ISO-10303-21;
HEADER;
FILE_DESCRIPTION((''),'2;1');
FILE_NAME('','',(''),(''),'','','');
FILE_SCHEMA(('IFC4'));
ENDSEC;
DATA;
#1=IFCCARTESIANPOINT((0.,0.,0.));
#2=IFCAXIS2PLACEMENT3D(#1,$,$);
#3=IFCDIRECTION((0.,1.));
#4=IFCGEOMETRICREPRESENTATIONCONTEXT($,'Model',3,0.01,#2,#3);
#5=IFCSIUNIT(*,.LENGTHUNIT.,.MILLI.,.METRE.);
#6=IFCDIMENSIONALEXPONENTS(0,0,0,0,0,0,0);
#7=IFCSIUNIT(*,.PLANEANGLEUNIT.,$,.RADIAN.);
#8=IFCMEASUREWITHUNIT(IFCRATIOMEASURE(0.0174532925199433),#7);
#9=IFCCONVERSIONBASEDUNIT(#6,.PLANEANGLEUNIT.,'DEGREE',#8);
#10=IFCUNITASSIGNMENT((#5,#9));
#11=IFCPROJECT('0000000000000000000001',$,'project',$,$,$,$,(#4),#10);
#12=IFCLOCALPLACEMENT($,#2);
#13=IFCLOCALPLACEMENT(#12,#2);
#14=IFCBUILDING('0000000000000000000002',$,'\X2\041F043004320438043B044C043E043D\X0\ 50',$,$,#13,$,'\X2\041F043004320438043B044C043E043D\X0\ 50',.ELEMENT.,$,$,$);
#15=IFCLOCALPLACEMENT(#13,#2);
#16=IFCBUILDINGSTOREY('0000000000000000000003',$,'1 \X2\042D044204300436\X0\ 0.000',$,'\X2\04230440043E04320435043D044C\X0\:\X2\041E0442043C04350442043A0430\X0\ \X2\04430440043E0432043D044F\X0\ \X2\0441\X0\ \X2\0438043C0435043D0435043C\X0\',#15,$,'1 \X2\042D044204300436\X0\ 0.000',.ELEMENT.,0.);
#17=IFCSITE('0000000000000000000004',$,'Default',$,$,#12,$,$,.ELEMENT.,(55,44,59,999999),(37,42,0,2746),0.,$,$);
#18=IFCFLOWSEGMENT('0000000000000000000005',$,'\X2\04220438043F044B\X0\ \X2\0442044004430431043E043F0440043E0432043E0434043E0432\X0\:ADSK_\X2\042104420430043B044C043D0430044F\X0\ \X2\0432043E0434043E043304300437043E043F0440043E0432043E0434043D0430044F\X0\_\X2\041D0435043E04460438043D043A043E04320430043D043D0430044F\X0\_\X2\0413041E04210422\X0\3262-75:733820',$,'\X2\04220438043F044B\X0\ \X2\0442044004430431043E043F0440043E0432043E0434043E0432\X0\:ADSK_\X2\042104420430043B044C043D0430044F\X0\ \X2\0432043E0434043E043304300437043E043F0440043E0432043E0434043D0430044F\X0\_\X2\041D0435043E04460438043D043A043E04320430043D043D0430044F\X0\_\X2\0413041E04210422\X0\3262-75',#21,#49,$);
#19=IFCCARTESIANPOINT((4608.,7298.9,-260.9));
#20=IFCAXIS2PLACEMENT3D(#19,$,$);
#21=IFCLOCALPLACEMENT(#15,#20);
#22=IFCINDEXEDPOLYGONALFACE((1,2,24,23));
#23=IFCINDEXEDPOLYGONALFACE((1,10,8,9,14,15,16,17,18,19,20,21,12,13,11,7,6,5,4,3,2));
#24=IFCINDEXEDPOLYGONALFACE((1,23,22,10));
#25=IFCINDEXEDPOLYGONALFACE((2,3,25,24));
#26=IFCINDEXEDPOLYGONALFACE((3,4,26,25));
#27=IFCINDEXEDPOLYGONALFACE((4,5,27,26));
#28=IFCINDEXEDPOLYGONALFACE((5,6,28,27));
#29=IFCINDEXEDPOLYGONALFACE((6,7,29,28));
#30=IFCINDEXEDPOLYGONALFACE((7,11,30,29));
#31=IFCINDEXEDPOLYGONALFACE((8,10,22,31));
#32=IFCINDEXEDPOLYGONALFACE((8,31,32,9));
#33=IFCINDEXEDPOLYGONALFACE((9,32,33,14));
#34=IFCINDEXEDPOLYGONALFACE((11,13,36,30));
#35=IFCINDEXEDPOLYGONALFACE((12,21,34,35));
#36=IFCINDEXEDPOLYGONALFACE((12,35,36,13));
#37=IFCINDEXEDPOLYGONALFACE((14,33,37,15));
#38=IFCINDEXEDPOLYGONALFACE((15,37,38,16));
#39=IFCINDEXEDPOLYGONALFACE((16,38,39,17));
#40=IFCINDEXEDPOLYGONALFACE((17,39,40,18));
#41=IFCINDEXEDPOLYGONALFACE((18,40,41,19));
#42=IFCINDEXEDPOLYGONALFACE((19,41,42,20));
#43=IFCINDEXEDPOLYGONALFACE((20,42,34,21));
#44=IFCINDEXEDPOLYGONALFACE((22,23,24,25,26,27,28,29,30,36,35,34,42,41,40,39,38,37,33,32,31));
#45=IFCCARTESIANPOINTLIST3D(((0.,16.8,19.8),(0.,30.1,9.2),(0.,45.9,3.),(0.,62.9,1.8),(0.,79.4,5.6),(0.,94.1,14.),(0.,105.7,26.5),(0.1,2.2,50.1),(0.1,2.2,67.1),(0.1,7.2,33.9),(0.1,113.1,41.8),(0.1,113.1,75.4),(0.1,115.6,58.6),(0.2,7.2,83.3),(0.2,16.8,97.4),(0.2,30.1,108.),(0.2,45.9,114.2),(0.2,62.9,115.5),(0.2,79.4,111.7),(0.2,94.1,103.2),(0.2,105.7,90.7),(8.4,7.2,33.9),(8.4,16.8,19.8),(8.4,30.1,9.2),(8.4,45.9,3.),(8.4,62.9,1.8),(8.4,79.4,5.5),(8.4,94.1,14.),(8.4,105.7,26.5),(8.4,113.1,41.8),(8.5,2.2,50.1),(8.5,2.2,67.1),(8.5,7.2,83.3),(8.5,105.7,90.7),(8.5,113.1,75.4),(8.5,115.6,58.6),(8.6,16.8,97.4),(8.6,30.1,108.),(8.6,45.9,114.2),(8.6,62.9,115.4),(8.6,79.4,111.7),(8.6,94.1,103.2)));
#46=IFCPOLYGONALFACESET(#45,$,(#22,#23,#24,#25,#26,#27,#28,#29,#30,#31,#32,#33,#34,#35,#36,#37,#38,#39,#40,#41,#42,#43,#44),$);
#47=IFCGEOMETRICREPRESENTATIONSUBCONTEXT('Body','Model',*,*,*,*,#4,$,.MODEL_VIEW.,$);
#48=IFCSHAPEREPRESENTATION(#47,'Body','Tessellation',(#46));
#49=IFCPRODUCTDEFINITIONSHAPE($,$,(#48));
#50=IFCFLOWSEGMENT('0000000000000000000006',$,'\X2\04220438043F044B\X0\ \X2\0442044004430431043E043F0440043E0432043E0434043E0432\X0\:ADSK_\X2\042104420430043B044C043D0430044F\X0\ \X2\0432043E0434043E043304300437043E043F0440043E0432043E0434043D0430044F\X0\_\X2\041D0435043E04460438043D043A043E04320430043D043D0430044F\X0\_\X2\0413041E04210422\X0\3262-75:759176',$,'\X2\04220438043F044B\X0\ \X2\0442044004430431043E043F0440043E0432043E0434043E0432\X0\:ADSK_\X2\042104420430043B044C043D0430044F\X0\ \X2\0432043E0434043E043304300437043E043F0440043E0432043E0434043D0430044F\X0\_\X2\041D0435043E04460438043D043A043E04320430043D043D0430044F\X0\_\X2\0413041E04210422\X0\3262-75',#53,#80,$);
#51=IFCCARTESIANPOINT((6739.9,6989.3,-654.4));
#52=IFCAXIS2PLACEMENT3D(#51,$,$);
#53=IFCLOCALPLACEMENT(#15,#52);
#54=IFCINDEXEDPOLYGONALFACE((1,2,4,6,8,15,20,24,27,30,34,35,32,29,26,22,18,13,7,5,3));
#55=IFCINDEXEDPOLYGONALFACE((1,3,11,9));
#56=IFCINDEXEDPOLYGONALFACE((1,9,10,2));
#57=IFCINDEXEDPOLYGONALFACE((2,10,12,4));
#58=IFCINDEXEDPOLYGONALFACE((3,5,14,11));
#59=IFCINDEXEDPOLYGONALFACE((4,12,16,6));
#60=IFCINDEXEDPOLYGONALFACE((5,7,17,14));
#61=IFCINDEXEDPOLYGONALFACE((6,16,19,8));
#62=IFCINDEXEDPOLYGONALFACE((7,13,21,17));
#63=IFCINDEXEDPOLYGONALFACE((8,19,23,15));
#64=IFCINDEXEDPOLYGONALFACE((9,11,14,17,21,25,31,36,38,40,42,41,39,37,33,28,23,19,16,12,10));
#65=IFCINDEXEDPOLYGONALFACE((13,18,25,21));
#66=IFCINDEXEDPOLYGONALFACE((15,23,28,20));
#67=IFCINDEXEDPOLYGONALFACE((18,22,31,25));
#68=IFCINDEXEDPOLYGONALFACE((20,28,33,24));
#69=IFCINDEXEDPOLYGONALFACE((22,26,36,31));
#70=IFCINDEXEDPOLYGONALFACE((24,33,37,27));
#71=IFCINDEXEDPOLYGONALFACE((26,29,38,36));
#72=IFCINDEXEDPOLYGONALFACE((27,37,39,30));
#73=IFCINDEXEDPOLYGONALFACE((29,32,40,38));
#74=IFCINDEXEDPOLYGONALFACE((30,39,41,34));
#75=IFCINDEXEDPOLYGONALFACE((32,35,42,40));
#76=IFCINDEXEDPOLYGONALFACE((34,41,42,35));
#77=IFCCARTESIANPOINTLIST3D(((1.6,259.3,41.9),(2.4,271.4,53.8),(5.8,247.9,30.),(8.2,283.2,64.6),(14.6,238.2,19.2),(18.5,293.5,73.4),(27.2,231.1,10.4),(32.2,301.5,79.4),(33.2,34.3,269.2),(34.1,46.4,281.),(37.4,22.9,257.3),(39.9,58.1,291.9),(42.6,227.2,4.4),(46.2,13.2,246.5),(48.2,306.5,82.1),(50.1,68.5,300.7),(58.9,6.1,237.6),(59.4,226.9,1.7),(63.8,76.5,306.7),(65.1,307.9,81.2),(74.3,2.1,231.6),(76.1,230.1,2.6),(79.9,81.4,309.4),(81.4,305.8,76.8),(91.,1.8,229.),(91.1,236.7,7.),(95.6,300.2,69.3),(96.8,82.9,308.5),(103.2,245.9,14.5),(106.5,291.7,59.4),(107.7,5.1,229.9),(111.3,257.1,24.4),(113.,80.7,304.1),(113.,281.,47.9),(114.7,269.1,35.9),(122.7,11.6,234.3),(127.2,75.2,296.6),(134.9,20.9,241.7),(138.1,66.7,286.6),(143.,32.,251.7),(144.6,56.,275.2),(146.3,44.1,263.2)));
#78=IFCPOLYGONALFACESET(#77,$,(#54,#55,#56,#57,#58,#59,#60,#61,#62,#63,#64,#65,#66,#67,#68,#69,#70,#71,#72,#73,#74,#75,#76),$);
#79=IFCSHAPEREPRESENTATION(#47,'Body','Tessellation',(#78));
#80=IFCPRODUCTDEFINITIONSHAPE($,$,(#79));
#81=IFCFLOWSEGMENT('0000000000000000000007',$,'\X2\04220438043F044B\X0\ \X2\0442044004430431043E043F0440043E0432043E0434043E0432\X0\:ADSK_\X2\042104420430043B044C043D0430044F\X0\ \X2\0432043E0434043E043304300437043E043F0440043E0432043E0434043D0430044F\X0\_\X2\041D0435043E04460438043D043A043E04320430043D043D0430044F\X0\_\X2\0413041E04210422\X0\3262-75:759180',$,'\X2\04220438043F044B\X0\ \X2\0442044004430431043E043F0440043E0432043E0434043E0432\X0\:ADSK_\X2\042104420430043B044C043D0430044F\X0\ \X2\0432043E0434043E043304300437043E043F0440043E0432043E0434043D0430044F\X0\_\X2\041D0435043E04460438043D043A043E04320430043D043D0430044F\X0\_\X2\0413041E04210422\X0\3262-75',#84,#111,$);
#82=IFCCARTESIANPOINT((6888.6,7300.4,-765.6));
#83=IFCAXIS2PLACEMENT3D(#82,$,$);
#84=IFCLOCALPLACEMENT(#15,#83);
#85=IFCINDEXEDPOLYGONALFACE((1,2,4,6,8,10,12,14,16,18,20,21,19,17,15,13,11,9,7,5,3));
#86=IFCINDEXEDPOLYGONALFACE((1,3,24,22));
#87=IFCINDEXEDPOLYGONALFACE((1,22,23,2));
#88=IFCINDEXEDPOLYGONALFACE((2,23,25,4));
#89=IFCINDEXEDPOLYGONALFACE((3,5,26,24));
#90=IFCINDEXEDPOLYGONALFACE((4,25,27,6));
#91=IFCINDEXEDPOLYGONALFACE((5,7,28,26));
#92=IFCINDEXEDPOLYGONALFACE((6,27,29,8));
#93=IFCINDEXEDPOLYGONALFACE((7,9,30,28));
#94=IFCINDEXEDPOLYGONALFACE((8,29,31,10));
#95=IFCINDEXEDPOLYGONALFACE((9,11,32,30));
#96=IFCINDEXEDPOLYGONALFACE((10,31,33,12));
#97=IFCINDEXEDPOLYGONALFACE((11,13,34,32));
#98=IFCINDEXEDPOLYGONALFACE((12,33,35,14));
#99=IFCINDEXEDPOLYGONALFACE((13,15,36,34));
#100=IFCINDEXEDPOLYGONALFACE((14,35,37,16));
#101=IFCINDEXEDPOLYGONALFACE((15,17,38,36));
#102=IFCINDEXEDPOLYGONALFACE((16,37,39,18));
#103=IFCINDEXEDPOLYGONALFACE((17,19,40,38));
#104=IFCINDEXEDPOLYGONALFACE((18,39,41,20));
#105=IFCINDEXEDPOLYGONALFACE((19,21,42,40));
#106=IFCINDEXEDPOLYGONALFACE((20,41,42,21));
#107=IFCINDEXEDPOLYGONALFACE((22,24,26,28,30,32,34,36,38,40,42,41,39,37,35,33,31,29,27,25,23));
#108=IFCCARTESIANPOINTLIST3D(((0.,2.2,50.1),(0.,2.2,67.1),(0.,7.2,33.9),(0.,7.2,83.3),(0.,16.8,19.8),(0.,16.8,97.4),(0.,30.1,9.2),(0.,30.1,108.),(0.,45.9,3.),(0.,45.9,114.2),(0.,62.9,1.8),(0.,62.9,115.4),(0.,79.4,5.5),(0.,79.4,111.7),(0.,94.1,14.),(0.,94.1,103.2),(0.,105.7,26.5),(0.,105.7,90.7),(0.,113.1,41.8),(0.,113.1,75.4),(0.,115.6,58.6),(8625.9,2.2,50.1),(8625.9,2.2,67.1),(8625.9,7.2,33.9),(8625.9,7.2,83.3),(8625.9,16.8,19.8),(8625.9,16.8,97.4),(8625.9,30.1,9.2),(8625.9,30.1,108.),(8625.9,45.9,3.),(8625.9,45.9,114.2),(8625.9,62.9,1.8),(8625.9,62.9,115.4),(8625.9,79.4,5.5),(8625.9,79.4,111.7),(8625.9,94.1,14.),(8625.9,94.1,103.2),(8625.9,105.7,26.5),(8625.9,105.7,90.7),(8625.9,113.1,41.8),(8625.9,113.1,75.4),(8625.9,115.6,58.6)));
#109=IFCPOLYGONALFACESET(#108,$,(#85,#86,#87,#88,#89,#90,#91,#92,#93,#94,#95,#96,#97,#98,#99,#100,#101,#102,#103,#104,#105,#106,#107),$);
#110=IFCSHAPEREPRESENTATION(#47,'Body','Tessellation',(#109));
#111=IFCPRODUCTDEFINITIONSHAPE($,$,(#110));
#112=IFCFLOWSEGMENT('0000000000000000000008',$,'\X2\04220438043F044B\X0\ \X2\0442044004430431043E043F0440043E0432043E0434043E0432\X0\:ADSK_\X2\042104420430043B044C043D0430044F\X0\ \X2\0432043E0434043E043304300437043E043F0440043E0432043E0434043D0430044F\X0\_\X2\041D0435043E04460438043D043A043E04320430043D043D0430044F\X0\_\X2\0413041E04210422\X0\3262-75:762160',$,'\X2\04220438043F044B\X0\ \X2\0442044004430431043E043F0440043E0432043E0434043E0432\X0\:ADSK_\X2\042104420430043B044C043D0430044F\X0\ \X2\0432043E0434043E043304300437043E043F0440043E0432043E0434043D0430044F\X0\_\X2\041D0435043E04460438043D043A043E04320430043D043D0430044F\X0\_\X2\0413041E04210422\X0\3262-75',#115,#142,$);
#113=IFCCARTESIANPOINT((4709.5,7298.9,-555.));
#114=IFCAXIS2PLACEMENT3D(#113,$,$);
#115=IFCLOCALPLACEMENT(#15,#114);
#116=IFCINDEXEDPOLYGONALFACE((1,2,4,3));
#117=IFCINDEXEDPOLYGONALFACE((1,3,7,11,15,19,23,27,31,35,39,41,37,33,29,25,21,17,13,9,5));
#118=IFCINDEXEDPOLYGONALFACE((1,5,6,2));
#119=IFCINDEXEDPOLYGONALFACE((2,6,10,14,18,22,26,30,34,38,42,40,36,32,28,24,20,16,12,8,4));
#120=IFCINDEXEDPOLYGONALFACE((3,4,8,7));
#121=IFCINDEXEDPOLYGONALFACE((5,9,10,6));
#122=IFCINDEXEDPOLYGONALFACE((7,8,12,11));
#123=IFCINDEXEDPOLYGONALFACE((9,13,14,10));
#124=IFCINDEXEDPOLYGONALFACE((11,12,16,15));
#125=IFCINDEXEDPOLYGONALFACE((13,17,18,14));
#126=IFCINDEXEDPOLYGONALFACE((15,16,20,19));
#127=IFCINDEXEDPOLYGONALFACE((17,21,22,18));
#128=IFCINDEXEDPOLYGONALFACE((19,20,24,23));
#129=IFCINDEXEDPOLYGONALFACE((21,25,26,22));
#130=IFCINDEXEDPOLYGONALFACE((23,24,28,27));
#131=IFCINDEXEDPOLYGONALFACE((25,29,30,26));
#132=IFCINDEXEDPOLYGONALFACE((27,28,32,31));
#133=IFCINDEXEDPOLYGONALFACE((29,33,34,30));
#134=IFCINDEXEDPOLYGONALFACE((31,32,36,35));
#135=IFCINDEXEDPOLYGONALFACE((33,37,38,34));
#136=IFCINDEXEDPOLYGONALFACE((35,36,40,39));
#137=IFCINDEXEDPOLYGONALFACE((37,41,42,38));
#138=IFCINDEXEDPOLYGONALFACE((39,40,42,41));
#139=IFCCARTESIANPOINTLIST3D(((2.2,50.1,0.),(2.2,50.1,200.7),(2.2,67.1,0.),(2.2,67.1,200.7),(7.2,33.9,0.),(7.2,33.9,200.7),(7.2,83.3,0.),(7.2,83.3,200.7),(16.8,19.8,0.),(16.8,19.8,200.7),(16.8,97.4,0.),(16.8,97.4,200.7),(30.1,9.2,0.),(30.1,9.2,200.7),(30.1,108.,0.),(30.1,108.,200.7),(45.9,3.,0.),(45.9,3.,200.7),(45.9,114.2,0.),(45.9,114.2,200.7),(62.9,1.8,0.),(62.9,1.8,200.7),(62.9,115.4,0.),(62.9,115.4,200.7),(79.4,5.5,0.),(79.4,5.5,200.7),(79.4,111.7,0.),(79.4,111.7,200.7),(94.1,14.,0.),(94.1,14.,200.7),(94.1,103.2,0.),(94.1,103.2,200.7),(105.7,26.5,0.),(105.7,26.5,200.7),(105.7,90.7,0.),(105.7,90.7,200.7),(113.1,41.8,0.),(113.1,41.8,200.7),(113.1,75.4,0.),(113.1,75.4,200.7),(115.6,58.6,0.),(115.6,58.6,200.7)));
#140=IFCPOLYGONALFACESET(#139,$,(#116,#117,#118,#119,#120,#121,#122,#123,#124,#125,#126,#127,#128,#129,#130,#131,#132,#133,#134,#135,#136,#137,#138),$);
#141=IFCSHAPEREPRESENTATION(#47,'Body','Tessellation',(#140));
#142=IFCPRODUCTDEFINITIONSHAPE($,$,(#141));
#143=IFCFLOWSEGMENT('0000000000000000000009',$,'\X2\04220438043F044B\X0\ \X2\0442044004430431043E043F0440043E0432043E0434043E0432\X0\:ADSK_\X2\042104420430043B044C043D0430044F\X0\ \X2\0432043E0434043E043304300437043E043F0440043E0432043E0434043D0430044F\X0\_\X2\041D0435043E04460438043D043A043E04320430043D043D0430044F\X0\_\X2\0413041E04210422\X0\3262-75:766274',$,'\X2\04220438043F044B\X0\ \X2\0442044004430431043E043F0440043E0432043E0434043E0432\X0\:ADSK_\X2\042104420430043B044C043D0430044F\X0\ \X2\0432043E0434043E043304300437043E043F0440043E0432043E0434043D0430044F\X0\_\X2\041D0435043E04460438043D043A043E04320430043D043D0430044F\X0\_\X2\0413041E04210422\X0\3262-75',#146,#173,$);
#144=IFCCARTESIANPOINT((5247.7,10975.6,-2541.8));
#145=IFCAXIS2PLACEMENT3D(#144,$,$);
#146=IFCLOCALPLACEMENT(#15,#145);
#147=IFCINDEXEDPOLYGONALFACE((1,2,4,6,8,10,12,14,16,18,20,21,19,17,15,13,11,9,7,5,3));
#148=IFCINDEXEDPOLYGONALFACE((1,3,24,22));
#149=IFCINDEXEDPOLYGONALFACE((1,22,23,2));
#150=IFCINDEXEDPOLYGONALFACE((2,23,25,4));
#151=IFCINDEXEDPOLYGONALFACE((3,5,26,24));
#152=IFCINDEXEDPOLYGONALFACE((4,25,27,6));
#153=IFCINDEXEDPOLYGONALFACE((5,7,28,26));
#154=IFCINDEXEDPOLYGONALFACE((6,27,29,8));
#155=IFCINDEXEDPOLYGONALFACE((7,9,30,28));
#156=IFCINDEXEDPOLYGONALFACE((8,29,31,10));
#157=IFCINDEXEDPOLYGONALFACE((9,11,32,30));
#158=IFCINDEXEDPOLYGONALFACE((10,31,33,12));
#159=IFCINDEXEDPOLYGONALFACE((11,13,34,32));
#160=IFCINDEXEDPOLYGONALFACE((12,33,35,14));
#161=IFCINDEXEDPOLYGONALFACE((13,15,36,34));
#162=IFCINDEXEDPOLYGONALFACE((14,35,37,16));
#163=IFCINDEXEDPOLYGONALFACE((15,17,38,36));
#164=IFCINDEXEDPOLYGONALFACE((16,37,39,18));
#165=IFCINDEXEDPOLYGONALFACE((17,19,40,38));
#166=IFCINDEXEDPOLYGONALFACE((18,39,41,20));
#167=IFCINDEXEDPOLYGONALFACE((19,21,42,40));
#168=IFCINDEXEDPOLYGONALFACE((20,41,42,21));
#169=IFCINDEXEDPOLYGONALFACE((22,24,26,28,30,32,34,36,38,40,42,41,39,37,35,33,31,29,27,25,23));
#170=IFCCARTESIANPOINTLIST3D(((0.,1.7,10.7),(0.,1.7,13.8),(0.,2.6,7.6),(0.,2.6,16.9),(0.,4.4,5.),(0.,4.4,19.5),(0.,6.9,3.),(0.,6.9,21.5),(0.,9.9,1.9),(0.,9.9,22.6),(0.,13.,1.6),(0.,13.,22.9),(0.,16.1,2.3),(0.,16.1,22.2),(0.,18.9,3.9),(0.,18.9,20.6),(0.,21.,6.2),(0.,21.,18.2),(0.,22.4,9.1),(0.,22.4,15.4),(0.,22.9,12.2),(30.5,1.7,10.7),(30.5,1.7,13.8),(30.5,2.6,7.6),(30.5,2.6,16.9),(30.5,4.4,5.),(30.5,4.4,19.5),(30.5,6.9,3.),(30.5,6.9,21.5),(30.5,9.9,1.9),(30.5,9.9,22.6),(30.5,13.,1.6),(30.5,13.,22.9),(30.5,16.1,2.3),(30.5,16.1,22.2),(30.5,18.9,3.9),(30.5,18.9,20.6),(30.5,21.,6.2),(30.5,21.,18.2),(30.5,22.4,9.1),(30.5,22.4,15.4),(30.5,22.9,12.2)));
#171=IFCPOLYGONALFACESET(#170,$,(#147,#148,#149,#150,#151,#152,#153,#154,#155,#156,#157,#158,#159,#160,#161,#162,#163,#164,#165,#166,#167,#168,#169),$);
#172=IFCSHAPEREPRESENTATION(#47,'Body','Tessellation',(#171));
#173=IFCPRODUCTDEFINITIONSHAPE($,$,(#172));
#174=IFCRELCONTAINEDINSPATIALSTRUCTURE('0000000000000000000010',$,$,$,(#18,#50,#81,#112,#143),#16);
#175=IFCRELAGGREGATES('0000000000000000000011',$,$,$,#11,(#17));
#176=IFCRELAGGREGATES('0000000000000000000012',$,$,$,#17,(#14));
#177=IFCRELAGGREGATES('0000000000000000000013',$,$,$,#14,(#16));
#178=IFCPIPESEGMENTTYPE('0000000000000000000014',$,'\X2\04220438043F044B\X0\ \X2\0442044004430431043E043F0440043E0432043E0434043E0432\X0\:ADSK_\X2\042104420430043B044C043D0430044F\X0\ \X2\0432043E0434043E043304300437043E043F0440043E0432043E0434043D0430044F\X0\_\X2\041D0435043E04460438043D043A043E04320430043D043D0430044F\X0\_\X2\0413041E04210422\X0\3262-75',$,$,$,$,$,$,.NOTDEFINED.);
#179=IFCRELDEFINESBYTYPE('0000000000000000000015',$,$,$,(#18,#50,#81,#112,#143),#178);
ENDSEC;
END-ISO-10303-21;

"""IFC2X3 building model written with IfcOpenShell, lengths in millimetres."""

from ifc_helpers import new_model, entity, si_unit, converted_unit, direction, frame, frame_2d, origin, origin_2d_with_axis, place, context, subcontext, project, spatial, circle, extrude, type_object, element, save


model = new_model("IFC2X3")

# Units and contexts
model_context = context("Model", 3, precision=0.01, world=origin(), true_north=direction((0.0, 1.0)))
body_context = subcontext(model_context, "Body", "Model", "MODEL_VIEW")
ifc_project = project(units=[si_unit("LENGTHUNIT", "METRE", prefix="MILLI"), converted_unit("PLANEANGLEUNIT", "DEGREE", entity("IfcRatioMeasure", 0.0174532925199433), si_unit("PLANEANGLEUNIT", "RADIAN"), dimensions=[0, 0, 0, 0, 0, 0, 0])], contexts=[model_context])

# Site, building, storey
site_placement = place(None, origin())
site = spatial("IfcSite", under=ifc_project, at=site_placement, Name="Default", CompositionType="ELEMENT", RefLatitude=(55, 44, 59, 999999), RefLongitude=(37, 42, 0, 2746), RefElevation=0.0)
building_placement = place(site_placement, origin())
building = spatial("IfcBuilding", under=site, at=building_placement, Name="Павильон 50", LongName="Павильон 50", CompositionType="ELEMENT")
storey_placement = place(building_placement, origin())
storey = spatial("IfcBuildingStorey", under=building, at=storey_placement, Name="1 Этаж 0.000", ObjectType="Уровень:Отметка уровня с именем", LongName="1 Этаж 0.000", CompositionType="ELEMENT", Elevation=0.0)

# Flow segments
pipe_segment_type = type_object("IfcPipeSegmentType", Name="Типы трубопроводов:ADSK_Стальная водогазопроводная_Неоцинкованная_ГОСТ3262-75", PredefinedType="NOTDEFINED")
flow_segment_1_placement = place(storey_placement, frame((4608.0, 7298.9, -260.9)))
element("IfcFlowSegment", 1, at=flow_segment_1_placement, inside=storey, type_object=pipe_segment_type, Name="Типы трубопроводов:ADSK_Стальная водогазопроводная_Неоцинкованная_ГОСТ3262-75:733820", ObjectType="Типы трубопроводов:ADSK_Стальная водогазопроводная_Неоцинкованная_ГОСТ3262-75", context=body_context, shape_type="SweptSolid", body=[
    extrude(circle(Radius=57.0, at=frame_2d((0.0, 0.0), x_axis=(1.0, 0.0))), frame((8.5, 58.6, 58.6), z_axis=(-0.999998, 0.0, 0.001998), x_axis=(0.0, 1.0, 0.0)), (0.0, 0.0, 1.0), 8.4),
])
flow_segment_2_placement = place(storey_placement, frame((6739.9, 6989.3, -654.4)))
element("IfcFlowSegment", 2, at=flow_segment_2_placement, inside=storey, type_object=pipe_segment_type, Name="Типы трубопроводов:ADSK_Стальная водогазопроводная_Неоцинкованная_ГОСТ3262-75:759176", ObjectType="Типы трубопроводов:ADSK_Стальная водогазопроводная_Неоцинкованная_ГОСТ3262-75", context=body_context, shape_type="SweptSolid", body=[
    extrude(circle(Radius=57.0, at=frame_2d((0.0, 0.0), x_axis=(1.0, 0.0))), frame((89.7, 42.2, 269.2), z_axis=(-0.09841, 0.700225, -0.707107), x_axis=(-0.990268, -0.139173, 0.0)), (0.0, 0.0, 1.0), 321.4),
])
flow_segment_3_placement = place(storey_placement, frame((6888.6, 7300.4, -765.6)))
element("IfcFlowSegment", 3, at=flow_segment_3_placement, inside=storey, type_object=pipe_segment_type, Name="Типы трубопроводов:ADSK_Стальная водогазопроводная_Неоцинкованная_ГОСТ3262-75:759180", ObjectType="Типы трубопроводов:ADSK_Стальная водогазопроводная_Неоцинкованная_ГОСТ3262-75", context=body_context, shape_type="SweptSolid", body=[
    extrude(circle(Radius=57.0, at=origin_2d_with_axis()), frame((0.0, 58.6, 58.6), z_axis=(1.0, 0.0, 0.0), x_axis=(0.0, 1.0, 0.0)), (0.0, 0.0, 1.0), 8625.9),
])
flow_segment_4_placement = place(storey_placement, frame((4709.5, 7298.9, -555.0)))
element("IfcFlowSegment", 4, at=flow_segment_4_placement, inside=storey, type_object=pipe_segment_type, Name="Типы трубопроводов:ADSK_Стальная водогазопроводная_Неоцинкованная_ГОСТ3262-75:762160", ObjectType="Типы трубопроводов:ADSK_Стальная водогазопроводная_Неоцинкованная_ГОСТ3262-75", context=body_context, shape_type="SweptSolid", body=[
    extrude(circle(Radius=57.0, at=origin_2d_with_axis()), frame((58.6, 58.6, 0.0)), (0.0, 0.0, 1.0), 200.7),
])
flow_segment_5_placement = place(storey_placement, frame((5247.7, 10975.6, -2541.8)))
element("IfcFlowSegment", 5, at=flow_segment_5_placement, inside=storey, type_object=pipe_segment_type, Name="Типы трубопроводов:ADSK_Стальная водогазопроводная_Неоцинкованная_ГОСТ3262-75:766274", ObjectType="Типы трубопроводов:ADSK_Стальная водогазопроводная_Неоцинкованная_ГОСТ3262-75", context=body_context, shape_type="SweptSolid", body=[
    extrude(circle(Radius=10.7, at=frame_2d((0.0, 0.0), x_axis=(1.0, 0.0))), frame((0.0, 12.2, 12.2), z_axis=(1.0, 0.0, 0.0), x_axis=(0.0, 1.0, 0.0)), (0.0, 0.0, 1.0), 30.5),
])

save(model, "model.ifc")
